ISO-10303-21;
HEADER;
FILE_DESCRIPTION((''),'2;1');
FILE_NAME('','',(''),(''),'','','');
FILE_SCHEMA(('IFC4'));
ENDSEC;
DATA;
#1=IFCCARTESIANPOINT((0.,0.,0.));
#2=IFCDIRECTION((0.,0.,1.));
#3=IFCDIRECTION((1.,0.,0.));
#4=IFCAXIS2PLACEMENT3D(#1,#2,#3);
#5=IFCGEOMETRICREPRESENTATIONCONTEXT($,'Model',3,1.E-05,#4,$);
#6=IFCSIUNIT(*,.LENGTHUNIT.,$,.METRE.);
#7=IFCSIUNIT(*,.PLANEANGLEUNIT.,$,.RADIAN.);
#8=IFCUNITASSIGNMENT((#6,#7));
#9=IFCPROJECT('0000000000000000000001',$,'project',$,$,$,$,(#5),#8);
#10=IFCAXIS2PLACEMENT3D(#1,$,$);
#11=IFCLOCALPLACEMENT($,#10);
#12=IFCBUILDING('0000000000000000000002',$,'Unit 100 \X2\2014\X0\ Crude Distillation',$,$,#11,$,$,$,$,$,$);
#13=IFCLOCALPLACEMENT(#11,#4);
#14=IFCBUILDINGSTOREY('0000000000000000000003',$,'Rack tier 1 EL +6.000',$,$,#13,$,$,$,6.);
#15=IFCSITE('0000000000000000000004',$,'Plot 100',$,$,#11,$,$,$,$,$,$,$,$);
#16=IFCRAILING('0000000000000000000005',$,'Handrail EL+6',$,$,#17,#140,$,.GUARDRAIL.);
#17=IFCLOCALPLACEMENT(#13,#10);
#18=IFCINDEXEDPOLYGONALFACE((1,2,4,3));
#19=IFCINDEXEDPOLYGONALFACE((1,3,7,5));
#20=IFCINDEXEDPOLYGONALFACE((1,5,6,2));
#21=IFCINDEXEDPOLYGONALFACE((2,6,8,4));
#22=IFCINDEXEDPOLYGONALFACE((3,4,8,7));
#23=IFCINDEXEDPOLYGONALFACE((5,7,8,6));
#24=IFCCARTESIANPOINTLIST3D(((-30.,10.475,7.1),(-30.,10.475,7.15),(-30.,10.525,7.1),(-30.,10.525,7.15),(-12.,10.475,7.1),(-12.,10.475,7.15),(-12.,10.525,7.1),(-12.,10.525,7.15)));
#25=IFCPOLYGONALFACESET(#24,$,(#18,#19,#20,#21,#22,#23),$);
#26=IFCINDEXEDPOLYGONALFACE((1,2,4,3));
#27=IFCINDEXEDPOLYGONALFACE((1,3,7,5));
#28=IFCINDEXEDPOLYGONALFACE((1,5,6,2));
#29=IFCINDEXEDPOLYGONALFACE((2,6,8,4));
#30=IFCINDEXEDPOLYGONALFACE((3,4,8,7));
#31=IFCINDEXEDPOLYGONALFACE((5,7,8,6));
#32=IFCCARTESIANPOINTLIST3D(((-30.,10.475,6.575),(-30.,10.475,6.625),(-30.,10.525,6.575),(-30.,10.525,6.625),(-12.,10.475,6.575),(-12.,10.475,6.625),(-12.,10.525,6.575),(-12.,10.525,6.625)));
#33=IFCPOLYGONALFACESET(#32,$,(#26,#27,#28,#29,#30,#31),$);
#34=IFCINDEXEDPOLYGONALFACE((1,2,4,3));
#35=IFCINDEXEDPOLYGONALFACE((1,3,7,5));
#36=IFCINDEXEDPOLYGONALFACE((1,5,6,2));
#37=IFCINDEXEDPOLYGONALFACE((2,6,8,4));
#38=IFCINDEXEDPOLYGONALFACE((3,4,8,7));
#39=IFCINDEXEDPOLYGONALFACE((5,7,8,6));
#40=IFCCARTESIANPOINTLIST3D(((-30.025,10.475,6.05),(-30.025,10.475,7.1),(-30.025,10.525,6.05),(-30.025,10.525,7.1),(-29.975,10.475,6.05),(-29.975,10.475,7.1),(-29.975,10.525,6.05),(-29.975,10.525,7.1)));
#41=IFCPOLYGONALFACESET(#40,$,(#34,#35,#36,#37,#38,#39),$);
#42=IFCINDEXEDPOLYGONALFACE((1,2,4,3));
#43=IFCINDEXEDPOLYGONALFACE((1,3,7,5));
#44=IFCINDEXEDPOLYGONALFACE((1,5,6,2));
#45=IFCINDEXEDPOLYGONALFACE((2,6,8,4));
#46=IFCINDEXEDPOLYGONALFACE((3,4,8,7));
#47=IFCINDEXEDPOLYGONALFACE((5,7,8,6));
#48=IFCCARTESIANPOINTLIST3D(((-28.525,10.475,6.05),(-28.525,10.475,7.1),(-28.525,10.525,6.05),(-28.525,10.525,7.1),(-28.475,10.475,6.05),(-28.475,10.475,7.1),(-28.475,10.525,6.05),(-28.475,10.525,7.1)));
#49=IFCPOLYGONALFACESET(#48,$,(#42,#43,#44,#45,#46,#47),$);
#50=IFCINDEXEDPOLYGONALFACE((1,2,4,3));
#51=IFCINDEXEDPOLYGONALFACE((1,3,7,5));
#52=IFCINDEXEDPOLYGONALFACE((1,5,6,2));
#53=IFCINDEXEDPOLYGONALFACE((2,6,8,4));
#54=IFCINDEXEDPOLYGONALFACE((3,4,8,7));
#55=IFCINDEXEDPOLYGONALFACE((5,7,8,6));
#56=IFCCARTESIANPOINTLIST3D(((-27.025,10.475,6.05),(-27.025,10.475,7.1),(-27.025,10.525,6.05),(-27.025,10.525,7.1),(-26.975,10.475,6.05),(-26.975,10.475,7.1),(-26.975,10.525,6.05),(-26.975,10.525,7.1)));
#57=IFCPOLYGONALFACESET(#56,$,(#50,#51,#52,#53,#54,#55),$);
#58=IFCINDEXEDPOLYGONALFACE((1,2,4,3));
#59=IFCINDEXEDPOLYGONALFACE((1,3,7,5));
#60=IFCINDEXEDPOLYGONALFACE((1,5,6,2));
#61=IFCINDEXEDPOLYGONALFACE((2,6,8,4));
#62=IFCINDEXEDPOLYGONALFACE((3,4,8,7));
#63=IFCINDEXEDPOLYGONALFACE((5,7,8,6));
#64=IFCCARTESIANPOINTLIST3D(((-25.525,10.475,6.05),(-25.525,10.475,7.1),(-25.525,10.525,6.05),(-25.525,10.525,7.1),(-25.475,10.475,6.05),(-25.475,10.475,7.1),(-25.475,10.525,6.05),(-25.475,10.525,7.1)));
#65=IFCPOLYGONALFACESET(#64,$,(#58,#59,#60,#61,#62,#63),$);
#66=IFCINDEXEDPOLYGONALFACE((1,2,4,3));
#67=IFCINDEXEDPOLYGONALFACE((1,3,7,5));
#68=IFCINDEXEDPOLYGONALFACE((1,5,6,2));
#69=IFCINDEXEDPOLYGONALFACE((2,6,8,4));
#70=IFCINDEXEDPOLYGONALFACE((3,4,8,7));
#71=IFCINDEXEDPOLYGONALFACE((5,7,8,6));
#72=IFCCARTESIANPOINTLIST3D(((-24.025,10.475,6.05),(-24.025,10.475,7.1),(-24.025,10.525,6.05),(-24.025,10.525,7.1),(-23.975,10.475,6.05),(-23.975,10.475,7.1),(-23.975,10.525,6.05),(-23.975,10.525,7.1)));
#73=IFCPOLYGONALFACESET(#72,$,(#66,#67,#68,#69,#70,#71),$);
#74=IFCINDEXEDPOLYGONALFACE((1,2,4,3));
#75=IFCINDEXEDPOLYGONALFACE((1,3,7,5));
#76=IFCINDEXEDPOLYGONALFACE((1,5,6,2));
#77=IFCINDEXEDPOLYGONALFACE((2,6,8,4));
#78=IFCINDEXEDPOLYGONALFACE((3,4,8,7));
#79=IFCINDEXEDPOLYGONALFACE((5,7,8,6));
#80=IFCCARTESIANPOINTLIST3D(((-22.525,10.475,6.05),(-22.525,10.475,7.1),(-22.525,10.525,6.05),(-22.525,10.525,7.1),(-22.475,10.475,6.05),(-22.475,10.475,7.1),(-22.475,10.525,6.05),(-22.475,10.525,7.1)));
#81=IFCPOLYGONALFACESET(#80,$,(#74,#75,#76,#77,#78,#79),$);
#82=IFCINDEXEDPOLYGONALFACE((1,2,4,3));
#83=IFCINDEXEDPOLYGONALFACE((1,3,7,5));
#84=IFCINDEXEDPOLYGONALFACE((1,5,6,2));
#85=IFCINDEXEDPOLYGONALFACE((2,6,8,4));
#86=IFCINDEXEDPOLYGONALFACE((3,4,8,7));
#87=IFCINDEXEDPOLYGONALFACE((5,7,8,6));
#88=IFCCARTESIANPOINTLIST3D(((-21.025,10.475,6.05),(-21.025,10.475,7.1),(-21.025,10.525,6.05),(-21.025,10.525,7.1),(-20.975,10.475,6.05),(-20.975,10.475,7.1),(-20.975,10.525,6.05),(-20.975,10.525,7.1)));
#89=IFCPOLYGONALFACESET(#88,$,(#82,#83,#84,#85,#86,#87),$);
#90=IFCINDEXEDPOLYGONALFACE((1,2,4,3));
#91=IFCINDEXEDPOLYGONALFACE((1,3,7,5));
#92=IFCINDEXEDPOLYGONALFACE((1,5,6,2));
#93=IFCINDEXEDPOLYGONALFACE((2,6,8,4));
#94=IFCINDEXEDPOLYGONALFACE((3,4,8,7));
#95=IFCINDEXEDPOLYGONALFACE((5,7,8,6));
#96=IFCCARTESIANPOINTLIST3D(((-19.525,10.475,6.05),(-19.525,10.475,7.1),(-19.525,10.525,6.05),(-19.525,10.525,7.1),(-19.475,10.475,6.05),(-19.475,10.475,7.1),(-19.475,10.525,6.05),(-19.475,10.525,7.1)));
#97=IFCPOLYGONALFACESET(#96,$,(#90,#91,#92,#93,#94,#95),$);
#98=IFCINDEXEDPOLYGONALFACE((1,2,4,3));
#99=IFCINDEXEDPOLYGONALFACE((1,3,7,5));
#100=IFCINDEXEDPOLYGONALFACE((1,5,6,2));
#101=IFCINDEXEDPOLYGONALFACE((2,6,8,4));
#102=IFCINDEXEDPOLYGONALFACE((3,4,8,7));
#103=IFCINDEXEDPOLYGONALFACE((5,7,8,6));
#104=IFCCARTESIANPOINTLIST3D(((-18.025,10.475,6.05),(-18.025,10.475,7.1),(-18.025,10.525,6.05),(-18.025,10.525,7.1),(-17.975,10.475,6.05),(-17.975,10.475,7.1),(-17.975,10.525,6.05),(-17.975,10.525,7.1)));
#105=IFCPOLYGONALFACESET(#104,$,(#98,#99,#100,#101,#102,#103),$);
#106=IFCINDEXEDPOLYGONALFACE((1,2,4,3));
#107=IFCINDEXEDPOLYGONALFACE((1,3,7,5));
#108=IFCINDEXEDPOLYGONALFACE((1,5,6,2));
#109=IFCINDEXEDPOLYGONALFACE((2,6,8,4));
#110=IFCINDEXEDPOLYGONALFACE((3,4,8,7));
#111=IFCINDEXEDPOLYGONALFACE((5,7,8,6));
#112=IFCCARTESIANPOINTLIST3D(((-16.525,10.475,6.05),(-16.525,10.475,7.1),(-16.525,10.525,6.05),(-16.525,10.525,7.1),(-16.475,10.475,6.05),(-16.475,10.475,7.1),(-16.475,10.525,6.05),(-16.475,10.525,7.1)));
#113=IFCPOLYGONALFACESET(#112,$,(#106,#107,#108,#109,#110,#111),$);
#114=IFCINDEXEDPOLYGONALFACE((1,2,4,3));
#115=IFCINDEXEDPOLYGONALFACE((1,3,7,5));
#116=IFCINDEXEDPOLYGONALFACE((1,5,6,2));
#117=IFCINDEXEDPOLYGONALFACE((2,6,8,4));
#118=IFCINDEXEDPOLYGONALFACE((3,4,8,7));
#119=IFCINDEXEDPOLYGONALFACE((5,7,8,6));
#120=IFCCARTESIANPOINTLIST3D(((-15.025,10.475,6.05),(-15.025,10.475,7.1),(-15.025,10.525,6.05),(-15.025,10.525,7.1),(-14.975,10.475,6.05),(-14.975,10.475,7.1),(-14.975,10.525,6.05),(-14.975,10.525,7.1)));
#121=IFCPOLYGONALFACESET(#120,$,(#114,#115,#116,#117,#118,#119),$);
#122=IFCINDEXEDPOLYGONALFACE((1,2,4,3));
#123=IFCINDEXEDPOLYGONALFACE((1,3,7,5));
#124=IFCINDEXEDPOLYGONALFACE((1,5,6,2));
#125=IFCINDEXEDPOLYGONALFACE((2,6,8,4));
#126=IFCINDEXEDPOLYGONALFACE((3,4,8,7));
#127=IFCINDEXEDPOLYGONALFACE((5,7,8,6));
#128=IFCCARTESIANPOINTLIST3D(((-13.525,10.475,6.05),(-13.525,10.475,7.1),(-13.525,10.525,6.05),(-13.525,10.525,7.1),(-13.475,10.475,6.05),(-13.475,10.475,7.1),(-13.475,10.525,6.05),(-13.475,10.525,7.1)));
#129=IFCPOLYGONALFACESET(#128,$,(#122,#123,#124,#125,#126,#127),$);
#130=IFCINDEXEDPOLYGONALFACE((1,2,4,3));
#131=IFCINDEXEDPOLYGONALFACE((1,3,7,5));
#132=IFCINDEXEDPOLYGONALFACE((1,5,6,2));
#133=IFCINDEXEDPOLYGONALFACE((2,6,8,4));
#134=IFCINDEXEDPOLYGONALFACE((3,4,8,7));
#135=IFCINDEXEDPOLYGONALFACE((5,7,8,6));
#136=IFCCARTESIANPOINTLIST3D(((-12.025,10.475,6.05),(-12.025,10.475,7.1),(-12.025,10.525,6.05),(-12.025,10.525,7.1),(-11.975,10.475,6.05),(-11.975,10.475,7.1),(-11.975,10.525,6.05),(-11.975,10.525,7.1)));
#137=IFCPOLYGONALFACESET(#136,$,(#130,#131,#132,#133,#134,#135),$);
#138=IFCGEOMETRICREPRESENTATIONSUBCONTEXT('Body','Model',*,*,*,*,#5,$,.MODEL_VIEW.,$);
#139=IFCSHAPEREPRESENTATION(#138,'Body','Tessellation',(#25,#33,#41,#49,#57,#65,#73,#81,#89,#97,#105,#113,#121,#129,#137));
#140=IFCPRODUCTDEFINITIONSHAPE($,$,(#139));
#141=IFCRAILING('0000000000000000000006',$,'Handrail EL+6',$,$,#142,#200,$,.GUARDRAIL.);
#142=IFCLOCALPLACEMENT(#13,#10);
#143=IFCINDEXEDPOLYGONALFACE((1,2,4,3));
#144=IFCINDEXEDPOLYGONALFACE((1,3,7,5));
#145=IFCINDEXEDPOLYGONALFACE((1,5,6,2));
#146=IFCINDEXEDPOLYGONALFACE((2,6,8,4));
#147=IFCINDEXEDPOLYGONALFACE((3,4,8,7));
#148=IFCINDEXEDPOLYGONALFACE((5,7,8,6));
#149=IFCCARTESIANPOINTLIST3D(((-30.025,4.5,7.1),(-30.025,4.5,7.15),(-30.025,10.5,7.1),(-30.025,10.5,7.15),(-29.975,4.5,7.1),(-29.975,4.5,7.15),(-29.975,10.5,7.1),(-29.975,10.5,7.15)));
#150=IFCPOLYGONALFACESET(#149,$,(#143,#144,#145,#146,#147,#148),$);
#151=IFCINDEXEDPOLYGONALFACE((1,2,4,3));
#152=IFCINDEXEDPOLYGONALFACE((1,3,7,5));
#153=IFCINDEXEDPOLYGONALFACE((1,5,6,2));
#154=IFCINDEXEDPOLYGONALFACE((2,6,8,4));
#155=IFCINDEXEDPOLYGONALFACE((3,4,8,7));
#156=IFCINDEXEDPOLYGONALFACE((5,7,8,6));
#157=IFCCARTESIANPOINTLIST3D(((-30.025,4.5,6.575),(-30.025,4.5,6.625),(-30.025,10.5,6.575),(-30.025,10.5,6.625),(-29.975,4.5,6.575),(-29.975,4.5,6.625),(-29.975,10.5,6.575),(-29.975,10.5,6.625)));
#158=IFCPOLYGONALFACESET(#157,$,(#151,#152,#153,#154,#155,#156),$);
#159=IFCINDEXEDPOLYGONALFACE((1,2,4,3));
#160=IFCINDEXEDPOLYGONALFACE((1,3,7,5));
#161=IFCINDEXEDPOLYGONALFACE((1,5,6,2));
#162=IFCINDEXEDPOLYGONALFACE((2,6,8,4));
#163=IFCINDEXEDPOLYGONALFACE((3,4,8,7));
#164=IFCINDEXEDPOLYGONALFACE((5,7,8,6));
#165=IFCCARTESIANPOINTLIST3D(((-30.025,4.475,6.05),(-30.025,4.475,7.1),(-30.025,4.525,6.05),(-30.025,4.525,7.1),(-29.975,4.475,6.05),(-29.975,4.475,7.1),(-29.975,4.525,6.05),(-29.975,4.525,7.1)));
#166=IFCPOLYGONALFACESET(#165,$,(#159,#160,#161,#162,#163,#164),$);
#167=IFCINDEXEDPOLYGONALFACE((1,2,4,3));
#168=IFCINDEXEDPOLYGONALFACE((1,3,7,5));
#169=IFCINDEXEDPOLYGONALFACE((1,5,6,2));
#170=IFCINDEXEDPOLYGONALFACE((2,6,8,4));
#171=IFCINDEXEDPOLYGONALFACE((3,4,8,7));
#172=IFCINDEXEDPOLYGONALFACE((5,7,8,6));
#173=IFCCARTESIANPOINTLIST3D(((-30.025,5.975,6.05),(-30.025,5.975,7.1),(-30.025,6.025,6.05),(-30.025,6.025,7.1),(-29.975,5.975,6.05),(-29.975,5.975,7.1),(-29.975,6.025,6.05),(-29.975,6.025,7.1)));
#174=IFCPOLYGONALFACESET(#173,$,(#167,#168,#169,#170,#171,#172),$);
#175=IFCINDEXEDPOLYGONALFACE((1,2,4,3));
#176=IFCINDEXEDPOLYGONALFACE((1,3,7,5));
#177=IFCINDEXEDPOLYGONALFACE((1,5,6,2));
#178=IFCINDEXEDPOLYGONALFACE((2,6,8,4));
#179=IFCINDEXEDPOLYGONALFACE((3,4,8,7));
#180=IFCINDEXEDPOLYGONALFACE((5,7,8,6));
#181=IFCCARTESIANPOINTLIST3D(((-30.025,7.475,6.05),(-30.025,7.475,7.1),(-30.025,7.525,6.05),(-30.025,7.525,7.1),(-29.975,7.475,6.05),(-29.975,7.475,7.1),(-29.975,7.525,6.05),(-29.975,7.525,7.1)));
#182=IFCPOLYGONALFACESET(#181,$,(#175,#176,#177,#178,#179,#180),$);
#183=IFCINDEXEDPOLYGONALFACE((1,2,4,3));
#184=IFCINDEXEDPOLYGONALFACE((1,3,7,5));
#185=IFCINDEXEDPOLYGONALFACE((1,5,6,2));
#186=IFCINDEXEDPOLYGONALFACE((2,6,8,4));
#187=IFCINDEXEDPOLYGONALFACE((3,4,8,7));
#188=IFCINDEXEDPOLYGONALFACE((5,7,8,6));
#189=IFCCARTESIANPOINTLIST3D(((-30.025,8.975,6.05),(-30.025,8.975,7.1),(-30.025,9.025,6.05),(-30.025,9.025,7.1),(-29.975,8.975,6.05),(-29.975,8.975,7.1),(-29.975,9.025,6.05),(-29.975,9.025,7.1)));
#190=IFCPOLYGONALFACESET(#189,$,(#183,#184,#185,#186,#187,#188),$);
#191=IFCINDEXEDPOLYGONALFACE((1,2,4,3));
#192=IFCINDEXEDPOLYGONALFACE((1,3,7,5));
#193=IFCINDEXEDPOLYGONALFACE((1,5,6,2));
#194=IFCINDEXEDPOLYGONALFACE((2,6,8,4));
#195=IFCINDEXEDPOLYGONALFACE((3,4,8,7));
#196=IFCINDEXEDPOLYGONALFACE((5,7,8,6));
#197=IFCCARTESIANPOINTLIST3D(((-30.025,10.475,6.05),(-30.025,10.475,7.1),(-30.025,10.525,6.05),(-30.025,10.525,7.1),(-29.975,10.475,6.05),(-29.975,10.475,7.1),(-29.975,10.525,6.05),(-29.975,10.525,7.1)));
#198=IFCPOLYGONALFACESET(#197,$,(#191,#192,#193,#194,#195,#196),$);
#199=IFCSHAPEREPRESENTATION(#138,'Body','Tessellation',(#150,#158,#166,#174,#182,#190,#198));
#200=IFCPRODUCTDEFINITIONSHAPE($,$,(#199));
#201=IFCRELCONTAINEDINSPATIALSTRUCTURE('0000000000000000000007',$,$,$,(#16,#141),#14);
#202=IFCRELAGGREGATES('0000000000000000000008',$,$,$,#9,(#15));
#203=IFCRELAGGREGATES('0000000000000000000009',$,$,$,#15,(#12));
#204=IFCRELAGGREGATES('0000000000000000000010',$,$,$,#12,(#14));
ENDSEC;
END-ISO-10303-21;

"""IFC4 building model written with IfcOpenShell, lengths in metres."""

from ifc_helpers import new_model, si_unit, frame, origin, origin_with_axes, origin_2d, place, context, subcontext, project, spatial, rectangle, extrude, element, save


model = new_model("IFC4")

# Units and contexts
model_context = context("Model", 3, precision=1e-05, world=origin_with_axes())
body_context = subcontext(model_context, "Body", "Model", "MODEL_VIEW")
ifc_project = project(units=[si_unit("LENGTHUNIT", "METRE"), si_unit("PLANEANGLEUNIT", "RADIAN")], contexts=[model_context])

# Site, building, storey
placement = place(None, origin())
site = spatial("IfcSite", under=ifc_project, at=placement, Name="Plot 100")
building = spatial("IfcBuilding", under=site, at=placement, Name="Unit 100 — Crude Distillation")
storey_placement = place(placement, origin_with_axes())
storey = spatial("IfcBuildingStorey", under=building, at=storey_placement, Name="Rack tier 1 EL +6.000", Elevation=6.0)

# Railings
railing_1_placement = place(storey_placement, origin_with_axes())
element("IfcRailing", 1, at=railing_1_placement, inside=storey, Name="Handrail EL+6", PredefinedType="GUARDRAIL", context=body_context, shape_type="SweptSolid", body=[
    extrude(rectangle(XDim=0.05, YDim=0.05, at=origin_2d()), frame((-30.0, 10.5, 7.125), z_axis=(1.0, 0.0, 0.0), x_axis=(0.0, 1.0, 0.0)), (0.0, 0.0, 1.0), 18.0),
    extrude(rectangle(XDim=0.05, YDim=0.05, at=origin_2d()), frame((-30.0, 10.5, 6.6), z_axis=(1.0, 0.0, 0.0), x_axis=(0.0, 1.0, 0.0)), (0.0, 0.0, 1.0), 18.0),
    extrude(rectangle(XDim=0.05, YDim=0.05, at=origin_2d()), frame((-30.0, 10.5, 6.05), z_axis=(0.0, 0.0, 1.0), x_axis=(1.0, 0.0, 0.0)), (0.0, 0.0, 1.0), 1.05),
    extrude(rectangle(XDim=0.05, YDim=0.05, at=origin_2d()), frame((-28.5, 10.5, 6.05), z_axis=(0.0, 0.0, 1.0), x_axis=(1.0, 0.0, 0.0)), (0.0, 0.0, 1.0), 1.05),
    extrude(rectangle(XDim=0.05, YDim=0.05, at=origin_2d()), frame((-27.0, 10.5, 6.05), z_axis=(0.0, 0.0, 1.0), x_axis=(1.0, 0.0, 0.0)), (0.0, 0.0, 1.0), 1.05),
    extrude(rectangle(XDim=0.05, YDim=0.05, at=origin_2d()), frame((-25.5, 10.5, 6.05), z_axis=(0.0, 0.0, 1.0), x_axis=(1.0, 0.0, 0.0)), (0.0, 0.0, 1.0), 1.05),
    extrude(rectangle(XDim=0.05, YDim=0.05, at=origin_2d()), frame((-24.0, 10.5, 6.05), z_axis=(0.0, 0.0, 1.0), x_axis=(1.0, 0.0, 0.0)), (0.0, 0.0, 1.0), 1.05),
    extrude(rectangle(XDim=0.05, YDim=0.05, at=origin_2d()), frame((-22.5, 10.5, 6.05), z_axis=(0.0, 0.0, 1.0), x_axis=(1.0, 0.0, 0.0)), (0.0, 0.0, 1.0), 1.05),
    extrude(rectangle(XDim=0.05, YDim=0.05, at=origin_2d()), frame((-21.0, 10.5, 6.05), z_axis=(0.0, 0.0, 1.0), x_axis=(1.0, 0.0, 0.0)), (0.0, 0.0, 1.0), 1.05),
    extrude(rectangle(XDim=0.05, YDim=0.05, at=origin_2d()), frame((-19.5, 10.5, 6.05), z_axis=(0.0, 0.0, 1.0), x_axis=(1.0, 0.0, 0.0)), (0.0, 0.0, 1.0), 1.05),
    extrude(rectangle(XDim=0.05, YDim=0.05, at=origin_2d()), frame((-18.0, 10.5, 6.05), z_axis=(0.0, 0.0, 1.0), x_axis=(1.0, 0.0, 0.0)), (0.0, 0.0, 1.0), 1.05),
    extrude(rectangle(XDim=0.05, YDim=0.05, at=origin_2d()), frame((-16.5, 10.5, 6.05), z_axis=(0.0, 0.0, 1.0), x_axis=(1.0, 0.0, 0.0)), (0.0, 0.0, 1.0), 1.05),
    extrude(rectangle(XDim=0.05, YDim=0.05, at=origin_2d()), frame((-15.0, 10.5, 6.05), z_axis=(0.0, 0.0, 1.0), x_axis=(1.0, 0.0, 0.0)), (0.0, 0.0, 1.0), 1.05),
    extrude(rectangle(XDim=0.05, YDim=0.05, at=origin_2d()), frame((-13.5, 10.5, 6.05), z_axis=(0.0, 0.0, 1.0), x_axis=(1.0, 0.0, 0.0)), (0.0, 0.0, 1.0), 1.05),
    extrude(rectangle(XDim=0.05, YDim=0.05, at=origin_2d()), frame((-12.0, 10.5, 6.05), z_axis=(0.0, 0.0, 1.0), x_axis=(1.0, 0.0, 0.0)), (0.0, 0.0, 1.0), 1.05),
])
railing_2_placement = place(storey_placement, origin_with_axes())
element("IfcRailing", 2, at=railing_2_placement, inside=storey, Name="Handrail EL+6", PredefinedType="GUARDRAIL", context=body_context, shape_type="SweptSolid", body=[
    extrude(rectangle(XDim=0.05, YDim=0.05, at=origin_2d()), frame((-30.0, 4.5, 7.125), z_axis=(0.0, 1.0, 0.0), x_axis=(-1.0, 0.0, 0.0)), (0.0, 0.0, 1.0), 6.0),
    extrude(rectangle(XDim=0.05, YDim=0.05, at=origin_2d()), frame((-30.0, 4.5, 6.6), z_axis=(0.0, 1.0, 0.0), x_axis=(-1.0, 0.0, 0.0)), (0.0, 0.0, 1.0), 6.0),
    extrude(rectangle(XDim=0.05, YDim=0.05, at=origin_2d()), frame((-30.0, 4.5, 6.05), z_axis=(0.0, 0.0, 1.0), x_axis=(1.0, 0.0, 0.0)), (0.0, 0.0, 1.0), 1.05),
    extrude(rectangle(XDim=0.05, YDim=0.05, at=origin_2d()), frame((-30.0, 6.0, 6.05), z_axis=(0.0, 0.0, 1.0), x_axis=(1.0, 0.0, 0.0)), (0.0, 0.0, 1.0), 1.05),
    extrude(rectangle(XDim=0.05, YDim=0.05, at=origin_2d()), frame((-30.0, 7.5, 6.05), z_axis=(0.0, 0.0, 1.0), x_axis=(1.0, 0.0, 0.0)), (0.0, 0.0, 1.0), 1.05),
    extrude(rectangle(XDim=0.05, YDim=0.05, at=origin_2d()), frame((-30.0, 9.0, 6.05), z_axis=(0.0, 0.0, 1.0), x_axis=(1.0, 0.0, 0.0)), (0.0, 0.0, 1.0), 1.05),
    extrude(rectangle(XDim=0.05, YDim=0.05, at=origin_2d()), frame((-30.0, 10.5, 6.05), z_axis=(0.0, 0.0, 1.0), x_axis=(1.0, 0.0, 0.0)), (0.0, 0.0, 1.0), 1.05),
])

save(model, "model.ifc")
